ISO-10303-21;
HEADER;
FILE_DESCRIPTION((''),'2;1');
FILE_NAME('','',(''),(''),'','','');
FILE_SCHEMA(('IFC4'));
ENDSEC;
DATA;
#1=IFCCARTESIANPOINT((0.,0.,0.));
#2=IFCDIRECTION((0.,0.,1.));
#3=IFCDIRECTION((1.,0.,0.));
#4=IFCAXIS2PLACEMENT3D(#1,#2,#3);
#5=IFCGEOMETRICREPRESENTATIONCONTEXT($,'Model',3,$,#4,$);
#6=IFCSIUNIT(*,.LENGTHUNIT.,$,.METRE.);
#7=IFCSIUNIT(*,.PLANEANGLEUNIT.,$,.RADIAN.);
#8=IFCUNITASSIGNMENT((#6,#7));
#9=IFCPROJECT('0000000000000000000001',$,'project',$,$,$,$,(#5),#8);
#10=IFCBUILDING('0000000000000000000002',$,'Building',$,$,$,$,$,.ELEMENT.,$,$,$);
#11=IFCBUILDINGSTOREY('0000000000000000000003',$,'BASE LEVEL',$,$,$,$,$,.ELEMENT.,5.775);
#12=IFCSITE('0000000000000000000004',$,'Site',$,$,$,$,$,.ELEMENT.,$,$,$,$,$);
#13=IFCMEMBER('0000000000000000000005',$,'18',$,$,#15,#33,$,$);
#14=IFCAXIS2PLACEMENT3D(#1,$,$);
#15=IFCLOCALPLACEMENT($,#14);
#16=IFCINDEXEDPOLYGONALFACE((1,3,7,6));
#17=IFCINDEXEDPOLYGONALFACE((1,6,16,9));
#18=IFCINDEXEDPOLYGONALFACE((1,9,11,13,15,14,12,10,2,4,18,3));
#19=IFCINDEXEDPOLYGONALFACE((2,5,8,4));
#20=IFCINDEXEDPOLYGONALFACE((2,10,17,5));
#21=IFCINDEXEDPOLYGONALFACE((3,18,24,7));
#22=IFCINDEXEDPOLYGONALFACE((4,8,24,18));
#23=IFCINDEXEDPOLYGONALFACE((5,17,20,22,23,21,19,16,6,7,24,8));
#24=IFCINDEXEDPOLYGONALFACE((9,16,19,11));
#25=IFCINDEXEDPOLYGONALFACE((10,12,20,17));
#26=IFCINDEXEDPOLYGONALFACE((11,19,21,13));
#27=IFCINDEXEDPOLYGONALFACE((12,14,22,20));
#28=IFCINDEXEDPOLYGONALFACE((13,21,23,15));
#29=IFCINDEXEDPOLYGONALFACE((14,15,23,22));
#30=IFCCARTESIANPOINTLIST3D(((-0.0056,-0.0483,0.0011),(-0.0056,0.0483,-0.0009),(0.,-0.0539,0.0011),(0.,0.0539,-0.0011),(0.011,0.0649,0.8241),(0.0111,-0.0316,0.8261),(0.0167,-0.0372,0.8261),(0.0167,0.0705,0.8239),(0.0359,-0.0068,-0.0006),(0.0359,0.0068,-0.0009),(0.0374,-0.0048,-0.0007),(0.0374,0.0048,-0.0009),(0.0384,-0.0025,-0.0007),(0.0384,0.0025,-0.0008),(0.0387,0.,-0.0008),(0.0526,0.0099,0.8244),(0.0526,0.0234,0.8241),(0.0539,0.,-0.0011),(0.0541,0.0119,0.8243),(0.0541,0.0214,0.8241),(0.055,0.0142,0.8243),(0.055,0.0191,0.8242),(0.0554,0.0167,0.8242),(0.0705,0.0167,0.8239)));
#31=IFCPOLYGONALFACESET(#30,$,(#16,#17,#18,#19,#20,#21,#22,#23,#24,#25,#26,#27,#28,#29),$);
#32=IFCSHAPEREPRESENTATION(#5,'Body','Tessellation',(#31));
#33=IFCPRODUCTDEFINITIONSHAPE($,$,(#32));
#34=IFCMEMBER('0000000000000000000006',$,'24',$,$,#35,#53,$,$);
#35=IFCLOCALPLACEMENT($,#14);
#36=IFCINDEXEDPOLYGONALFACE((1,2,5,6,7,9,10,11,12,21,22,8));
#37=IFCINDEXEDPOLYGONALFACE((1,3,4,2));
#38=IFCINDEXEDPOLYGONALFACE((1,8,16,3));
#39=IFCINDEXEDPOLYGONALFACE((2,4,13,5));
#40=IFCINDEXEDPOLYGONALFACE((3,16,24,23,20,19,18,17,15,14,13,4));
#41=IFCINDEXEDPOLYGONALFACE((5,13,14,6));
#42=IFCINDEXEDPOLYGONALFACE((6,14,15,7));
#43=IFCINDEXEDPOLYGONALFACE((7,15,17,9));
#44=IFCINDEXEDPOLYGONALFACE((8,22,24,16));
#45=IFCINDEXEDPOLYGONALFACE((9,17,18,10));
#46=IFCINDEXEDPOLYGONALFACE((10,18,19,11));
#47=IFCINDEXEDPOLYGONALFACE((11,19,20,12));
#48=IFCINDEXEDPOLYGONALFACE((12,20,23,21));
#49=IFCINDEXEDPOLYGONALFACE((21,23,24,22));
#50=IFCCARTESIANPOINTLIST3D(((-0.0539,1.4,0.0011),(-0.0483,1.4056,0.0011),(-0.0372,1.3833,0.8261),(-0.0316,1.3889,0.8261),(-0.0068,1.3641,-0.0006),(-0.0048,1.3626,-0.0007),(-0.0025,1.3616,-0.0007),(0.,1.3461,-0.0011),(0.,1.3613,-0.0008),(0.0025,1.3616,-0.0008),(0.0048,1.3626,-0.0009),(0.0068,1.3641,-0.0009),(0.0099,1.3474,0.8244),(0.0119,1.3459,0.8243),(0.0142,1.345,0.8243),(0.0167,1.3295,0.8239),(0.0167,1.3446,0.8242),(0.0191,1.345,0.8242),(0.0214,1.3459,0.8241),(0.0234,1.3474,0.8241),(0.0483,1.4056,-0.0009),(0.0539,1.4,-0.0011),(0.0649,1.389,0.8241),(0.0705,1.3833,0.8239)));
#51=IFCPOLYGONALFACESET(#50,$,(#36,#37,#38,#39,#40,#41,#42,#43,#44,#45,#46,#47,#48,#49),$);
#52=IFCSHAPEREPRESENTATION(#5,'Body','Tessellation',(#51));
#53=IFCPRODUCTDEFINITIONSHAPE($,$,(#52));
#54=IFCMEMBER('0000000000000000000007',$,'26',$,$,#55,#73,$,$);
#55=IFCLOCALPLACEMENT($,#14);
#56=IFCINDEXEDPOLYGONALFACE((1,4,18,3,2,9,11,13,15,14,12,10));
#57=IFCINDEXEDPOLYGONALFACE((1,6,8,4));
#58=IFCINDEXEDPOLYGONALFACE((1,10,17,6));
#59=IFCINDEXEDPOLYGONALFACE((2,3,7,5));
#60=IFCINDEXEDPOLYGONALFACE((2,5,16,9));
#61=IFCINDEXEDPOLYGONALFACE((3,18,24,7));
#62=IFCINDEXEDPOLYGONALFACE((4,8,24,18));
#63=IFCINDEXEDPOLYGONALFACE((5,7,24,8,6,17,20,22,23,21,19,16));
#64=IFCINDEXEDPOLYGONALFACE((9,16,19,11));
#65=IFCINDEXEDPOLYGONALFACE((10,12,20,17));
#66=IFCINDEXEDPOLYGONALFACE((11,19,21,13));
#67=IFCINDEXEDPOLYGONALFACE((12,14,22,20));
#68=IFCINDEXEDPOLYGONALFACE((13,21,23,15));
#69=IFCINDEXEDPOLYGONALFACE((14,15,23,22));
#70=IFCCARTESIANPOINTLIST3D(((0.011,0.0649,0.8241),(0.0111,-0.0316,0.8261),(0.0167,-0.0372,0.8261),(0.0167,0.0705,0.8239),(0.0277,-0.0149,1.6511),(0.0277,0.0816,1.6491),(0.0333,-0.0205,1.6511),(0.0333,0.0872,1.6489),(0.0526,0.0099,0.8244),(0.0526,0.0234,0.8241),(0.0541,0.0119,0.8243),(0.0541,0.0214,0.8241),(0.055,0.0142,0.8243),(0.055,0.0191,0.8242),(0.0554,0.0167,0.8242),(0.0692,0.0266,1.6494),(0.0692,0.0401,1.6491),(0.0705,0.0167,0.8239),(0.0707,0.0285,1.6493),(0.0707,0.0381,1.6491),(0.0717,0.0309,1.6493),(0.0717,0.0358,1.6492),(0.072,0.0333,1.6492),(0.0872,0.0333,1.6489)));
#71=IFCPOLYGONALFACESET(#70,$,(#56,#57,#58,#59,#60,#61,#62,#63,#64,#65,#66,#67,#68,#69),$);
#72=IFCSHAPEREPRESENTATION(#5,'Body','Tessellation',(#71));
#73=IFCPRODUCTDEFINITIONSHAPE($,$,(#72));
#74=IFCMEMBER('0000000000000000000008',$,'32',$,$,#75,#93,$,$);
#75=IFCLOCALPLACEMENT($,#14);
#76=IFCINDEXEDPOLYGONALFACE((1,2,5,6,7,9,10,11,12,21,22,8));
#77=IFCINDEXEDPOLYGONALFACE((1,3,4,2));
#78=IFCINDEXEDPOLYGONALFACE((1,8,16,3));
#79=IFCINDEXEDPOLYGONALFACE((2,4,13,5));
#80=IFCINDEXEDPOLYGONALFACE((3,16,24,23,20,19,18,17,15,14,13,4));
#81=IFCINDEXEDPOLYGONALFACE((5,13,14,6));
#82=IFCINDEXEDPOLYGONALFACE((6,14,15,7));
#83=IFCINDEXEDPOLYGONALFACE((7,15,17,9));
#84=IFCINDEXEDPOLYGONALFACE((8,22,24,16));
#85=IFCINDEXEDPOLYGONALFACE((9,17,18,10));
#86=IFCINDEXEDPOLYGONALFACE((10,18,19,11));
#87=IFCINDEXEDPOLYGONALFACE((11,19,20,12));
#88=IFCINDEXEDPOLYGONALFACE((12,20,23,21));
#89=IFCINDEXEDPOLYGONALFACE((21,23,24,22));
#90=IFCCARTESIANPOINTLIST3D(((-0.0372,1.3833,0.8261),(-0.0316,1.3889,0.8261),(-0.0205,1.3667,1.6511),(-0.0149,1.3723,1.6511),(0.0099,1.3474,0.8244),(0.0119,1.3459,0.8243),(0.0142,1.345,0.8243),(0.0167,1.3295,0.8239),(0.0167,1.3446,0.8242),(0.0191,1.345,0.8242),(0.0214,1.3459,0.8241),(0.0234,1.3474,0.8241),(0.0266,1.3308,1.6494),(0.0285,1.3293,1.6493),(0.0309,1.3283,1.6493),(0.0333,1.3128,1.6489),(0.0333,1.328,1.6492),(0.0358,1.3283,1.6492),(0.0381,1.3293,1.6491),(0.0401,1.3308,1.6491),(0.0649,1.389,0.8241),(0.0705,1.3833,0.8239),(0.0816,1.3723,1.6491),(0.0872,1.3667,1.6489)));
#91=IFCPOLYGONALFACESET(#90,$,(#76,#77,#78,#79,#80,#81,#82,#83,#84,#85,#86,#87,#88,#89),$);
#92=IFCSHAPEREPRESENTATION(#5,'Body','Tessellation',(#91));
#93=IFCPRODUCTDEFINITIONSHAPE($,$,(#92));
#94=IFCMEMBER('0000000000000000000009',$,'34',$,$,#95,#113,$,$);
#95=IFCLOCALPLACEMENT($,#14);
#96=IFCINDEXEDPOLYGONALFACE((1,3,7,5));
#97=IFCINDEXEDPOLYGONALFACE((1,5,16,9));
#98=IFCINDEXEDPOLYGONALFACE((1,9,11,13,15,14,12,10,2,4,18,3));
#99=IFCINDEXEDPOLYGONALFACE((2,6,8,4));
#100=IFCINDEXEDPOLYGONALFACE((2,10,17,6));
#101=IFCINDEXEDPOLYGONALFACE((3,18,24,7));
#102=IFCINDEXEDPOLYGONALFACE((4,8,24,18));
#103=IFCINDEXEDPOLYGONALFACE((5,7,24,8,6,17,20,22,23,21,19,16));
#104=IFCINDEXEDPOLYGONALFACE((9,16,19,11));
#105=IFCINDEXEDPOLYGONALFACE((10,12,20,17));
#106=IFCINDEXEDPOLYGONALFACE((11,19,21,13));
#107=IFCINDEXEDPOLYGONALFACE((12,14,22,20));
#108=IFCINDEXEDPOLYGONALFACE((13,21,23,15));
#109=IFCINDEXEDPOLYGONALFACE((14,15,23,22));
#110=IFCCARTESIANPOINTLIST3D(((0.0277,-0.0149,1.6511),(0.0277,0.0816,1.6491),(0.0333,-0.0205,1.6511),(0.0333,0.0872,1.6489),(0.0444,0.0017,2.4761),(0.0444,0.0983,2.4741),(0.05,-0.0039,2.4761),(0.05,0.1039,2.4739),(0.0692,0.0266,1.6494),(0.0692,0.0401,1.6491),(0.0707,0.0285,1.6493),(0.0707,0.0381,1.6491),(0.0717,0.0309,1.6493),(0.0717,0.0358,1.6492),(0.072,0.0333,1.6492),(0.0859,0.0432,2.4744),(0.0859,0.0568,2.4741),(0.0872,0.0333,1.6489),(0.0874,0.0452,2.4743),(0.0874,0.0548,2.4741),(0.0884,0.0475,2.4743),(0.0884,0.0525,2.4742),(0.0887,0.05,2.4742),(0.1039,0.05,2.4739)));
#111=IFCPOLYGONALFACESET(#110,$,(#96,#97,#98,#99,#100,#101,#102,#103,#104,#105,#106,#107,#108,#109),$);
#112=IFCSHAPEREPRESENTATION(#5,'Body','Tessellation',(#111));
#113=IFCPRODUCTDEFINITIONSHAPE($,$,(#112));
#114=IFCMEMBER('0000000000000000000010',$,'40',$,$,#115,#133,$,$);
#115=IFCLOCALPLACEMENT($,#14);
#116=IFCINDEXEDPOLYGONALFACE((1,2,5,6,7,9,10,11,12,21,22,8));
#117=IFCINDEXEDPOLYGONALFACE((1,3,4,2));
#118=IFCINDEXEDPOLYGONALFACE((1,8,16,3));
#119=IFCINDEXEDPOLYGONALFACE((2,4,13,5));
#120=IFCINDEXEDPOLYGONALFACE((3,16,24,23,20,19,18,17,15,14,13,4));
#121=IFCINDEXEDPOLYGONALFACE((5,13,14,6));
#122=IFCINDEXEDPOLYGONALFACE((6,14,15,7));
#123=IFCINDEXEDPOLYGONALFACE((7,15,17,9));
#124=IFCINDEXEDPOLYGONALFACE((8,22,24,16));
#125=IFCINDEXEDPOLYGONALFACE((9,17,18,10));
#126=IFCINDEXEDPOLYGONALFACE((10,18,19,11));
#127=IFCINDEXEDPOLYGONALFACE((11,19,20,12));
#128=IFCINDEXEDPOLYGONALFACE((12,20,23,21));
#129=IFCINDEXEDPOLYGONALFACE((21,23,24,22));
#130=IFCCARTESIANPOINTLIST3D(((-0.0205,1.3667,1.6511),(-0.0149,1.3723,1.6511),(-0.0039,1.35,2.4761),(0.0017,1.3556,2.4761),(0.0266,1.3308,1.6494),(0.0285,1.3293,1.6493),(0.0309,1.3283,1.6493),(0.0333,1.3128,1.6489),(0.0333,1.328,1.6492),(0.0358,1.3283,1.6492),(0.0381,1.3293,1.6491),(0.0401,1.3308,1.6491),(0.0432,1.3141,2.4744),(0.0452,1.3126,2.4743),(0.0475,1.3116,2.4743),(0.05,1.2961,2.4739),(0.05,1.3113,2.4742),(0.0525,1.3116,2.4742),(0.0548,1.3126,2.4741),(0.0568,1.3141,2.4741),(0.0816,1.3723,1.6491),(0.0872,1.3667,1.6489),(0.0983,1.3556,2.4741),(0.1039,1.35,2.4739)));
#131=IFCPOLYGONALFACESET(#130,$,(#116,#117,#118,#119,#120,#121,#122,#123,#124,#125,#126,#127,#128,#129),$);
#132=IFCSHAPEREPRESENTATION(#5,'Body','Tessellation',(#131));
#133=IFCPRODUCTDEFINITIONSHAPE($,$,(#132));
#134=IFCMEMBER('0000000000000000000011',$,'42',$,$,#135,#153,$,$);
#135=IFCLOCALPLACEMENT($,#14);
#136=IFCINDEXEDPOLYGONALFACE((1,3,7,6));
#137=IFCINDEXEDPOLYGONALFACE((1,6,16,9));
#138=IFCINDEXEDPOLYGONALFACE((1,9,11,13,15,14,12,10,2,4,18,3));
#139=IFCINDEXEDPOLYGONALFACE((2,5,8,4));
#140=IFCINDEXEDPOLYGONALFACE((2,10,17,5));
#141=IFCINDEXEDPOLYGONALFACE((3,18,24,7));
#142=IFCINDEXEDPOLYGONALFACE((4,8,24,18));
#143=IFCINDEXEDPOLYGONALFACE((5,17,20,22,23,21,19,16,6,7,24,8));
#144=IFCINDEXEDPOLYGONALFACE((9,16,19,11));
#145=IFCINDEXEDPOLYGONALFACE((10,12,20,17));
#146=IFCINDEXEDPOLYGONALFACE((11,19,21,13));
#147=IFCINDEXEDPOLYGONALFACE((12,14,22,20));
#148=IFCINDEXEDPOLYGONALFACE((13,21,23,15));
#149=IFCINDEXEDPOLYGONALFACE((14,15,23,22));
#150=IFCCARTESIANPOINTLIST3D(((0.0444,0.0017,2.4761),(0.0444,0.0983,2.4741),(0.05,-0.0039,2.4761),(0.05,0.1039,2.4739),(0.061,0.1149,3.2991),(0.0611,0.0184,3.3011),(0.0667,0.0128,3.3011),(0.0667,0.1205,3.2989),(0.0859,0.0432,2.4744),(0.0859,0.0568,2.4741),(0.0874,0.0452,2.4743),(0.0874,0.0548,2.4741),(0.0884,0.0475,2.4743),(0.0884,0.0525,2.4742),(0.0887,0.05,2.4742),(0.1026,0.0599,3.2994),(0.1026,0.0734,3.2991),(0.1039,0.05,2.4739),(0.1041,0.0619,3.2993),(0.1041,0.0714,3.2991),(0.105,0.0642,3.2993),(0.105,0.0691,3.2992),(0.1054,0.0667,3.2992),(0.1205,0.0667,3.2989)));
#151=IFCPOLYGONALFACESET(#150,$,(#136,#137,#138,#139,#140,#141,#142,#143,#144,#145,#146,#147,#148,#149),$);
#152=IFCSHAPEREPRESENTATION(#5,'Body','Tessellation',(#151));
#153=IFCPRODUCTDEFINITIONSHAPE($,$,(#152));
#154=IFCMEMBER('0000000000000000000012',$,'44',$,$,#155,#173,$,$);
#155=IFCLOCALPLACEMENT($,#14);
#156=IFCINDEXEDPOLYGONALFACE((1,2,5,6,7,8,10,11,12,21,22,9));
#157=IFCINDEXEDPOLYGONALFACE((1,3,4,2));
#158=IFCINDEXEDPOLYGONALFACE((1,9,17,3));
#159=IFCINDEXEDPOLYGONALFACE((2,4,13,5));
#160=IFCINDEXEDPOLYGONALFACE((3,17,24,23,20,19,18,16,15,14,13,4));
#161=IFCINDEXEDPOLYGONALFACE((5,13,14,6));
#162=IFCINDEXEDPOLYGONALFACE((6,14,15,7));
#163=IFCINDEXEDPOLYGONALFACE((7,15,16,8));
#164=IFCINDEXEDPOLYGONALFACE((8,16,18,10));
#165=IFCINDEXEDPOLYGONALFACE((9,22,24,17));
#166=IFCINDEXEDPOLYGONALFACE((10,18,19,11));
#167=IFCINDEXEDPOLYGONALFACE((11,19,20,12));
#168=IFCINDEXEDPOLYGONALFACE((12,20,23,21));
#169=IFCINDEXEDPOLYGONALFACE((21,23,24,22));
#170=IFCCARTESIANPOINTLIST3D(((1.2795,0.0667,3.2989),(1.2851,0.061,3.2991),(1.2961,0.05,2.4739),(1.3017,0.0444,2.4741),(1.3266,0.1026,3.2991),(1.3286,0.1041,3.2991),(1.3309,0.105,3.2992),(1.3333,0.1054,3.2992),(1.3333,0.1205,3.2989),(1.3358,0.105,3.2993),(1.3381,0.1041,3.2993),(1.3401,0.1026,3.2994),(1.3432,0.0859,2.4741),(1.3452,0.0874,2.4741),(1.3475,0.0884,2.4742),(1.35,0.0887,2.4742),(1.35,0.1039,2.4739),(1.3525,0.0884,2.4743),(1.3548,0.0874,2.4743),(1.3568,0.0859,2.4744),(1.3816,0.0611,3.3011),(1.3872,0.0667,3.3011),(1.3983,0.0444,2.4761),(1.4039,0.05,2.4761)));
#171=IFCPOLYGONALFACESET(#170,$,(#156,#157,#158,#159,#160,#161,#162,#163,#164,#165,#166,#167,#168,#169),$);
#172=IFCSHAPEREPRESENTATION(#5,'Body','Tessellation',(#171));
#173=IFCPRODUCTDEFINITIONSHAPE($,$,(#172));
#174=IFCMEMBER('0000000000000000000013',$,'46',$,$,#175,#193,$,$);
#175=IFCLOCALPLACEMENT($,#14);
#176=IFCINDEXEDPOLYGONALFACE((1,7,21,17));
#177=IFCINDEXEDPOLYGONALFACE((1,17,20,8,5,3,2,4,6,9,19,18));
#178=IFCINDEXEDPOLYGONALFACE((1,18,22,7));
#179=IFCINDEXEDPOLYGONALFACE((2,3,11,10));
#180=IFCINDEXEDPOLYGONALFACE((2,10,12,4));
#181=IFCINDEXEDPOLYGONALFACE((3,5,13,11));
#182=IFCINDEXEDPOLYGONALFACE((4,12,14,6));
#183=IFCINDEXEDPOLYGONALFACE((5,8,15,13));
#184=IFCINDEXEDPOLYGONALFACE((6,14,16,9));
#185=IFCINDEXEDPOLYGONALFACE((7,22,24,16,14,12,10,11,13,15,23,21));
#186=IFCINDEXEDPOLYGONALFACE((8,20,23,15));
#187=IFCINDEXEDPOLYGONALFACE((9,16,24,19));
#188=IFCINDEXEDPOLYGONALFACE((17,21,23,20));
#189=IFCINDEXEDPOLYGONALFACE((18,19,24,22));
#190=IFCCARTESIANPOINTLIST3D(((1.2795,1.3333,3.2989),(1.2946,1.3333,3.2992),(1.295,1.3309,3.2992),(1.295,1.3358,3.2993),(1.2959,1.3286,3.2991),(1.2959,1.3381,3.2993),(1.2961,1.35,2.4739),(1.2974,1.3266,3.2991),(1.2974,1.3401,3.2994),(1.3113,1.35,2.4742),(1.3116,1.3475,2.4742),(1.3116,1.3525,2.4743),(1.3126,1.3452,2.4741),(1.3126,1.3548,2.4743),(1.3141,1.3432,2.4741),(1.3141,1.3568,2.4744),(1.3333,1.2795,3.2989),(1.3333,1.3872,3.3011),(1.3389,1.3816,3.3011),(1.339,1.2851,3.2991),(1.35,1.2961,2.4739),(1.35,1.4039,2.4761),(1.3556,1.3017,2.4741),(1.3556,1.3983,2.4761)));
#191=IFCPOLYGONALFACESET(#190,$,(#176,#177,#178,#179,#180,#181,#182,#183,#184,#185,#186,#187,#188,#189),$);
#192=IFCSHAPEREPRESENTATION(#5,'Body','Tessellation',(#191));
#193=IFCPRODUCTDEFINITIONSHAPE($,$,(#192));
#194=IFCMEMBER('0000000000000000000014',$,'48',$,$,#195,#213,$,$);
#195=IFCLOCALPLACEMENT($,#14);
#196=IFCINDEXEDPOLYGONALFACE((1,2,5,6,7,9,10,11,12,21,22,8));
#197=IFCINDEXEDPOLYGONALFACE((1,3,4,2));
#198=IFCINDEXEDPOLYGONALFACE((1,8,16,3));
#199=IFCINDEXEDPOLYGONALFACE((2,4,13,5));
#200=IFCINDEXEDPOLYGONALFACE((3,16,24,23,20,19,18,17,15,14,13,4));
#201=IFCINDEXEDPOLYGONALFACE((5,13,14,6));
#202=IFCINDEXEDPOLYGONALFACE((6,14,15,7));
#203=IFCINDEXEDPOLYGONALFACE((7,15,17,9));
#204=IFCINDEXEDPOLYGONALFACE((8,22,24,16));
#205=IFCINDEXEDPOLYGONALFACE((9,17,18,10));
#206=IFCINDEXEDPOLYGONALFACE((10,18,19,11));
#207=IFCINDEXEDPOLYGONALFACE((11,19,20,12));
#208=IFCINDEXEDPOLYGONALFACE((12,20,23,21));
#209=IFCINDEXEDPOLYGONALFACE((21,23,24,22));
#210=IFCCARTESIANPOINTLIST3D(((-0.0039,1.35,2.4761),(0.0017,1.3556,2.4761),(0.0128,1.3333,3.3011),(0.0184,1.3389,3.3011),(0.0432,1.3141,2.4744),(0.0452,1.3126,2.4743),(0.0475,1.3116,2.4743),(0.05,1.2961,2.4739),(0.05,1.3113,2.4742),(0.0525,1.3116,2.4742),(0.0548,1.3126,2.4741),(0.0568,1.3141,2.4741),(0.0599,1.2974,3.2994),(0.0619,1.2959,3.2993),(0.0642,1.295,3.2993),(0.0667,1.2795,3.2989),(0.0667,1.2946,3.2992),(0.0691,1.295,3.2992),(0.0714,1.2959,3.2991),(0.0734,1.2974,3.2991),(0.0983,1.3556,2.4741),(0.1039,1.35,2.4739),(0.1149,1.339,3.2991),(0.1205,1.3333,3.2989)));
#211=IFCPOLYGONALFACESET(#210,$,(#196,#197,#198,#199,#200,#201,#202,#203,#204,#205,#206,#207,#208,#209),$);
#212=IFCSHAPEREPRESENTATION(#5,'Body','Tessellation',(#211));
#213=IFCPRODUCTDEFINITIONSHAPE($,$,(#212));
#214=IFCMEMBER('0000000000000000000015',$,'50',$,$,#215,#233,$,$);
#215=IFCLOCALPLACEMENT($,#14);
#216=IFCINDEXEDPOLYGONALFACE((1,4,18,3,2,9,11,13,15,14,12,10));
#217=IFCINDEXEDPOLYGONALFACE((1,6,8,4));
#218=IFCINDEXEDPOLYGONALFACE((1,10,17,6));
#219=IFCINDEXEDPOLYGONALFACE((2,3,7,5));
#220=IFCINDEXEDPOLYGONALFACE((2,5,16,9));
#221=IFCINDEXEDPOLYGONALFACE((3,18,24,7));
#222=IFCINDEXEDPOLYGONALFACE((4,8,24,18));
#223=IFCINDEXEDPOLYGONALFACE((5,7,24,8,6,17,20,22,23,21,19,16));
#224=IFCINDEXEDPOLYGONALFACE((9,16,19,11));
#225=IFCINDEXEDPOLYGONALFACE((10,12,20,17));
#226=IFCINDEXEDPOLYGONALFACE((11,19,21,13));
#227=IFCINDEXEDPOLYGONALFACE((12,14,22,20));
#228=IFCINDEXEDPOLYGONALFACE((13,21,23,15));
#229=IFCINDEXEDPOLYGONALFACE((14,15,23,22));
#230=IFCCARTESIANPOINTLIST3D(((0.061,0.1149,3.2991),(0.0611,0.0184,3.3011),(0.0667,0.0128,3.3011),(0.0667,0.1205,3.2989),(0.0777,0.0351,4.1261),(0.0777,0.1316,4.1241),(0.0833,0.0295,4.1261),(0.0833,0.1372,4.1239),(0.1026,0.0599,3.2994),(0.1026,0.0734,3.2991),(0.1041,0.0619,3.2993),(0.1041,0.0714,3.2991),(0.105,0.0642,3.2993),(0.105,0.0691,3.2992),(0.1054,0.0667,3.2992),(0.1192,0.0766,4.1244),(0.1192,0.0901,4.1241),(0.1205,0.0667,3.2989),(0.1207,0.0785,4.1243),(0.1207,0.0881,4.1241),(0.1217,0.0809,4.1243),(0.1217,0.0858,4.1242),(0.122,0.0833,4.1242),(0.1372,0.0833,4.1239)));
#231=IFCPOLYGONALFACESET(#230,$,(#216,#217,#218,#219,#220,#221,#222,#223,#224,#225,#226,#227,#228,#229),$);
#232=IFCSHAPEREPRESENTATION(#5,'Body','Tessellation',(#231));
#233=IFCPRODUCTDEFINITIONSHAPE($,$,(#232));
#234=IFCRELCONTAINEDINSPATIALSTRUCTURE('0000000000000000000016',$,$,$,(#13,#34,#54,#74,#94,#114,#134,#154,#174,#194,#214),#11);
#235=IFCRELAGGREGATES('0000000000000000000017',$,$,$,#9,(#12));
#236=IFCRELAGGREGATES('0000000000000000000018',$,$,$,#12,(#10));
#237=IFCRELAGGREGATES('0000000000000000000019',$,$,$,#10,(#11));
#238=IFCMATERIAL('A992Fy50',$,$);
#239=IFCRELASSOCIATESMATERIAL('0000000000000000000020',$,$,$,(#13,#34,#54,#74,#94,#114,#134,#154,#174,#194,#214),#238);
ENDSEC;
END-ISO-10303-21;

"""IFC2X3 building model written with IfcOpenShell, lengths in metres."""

from ifc_helpers import new_model, si_unit, frame, origin_with_axes, origin_2d_with_axis, place, context, project, spatial, l_section, extrude, material, element, save


model = new_model("IFC2X3")

# Units and contexts
model_context = context("Model", 3, world=origin_with_axes())
ifc_project = project(units=[si_unit("LENGTHUNIT", "METRE"), si_unit("PLANEANGLEUNIT", "RADIAN")], contexts=[model_context])

# Site, building, storey
site = spatial("IfcSite", under=ifc_project, Name="Site", CompositionType="ELEMENT")
building = spatial("IfcBuilding", under=site, Name="Building", CompositionType="ELEMENT")
storey = spatial("IfcBuildingStorey", under=building, Name="BASE LEVEL", CompositionType="ELEMENT", Elevation=5.775)

# Members
ifc_material = material(Name="A992Fy50")
for number, where, z_axis, x_axis, name in (
    (1, (0.0, 0.0, 0.0), (0.020194, 0.020194, 0.999592), (-0.707107, 0.707107, 0.0), "18"),
    (2, (0.0, 1.4, 0.0), (0.020194, -0.020194, 0.999592), (0.707107, 0.707107, 0.0), "24"),
    (3, (0.0167, 0.0167, 0.825), (0.020194, 0.020194, 0.999592), (-0.707107, 0.707107, 0.0), "26"),
    (4, (0.0167, 1.3833, 0.825), (0.020194, -0.020194, 0.999592), (0.707107, 0.707107, 0.0), "32"),
    (5, (0.0333, 0.0333, 1.65), (0.020194, 0.020194, 0.999592), (-0.707107, 0.707107, 0.0), "34"),
    (6, (0.0333, 1.3667, 1.65), (0.020194, -0.020194, 0.999592), (0.707107, 0.707107, 0.0), "40"),
    (7, (0.05, 0.05, 2.475), (0.020194, 0.020194, 0.999592), (-0.707107, 0.707107, 0.0), "42"),
    (8, (1.35, 0.05, 2.475), (-0.020194, 0.020194, 0.999592), (-0.707107, -0.707107, 0.0), "44"),
    (9, (1.35, 1.35, 2.475), (-0.020194, -0.020194, 0.999592), (0.707107, -0.707107, 0.0), "46"),
    (10, (0.05, 1.35, 2.475), (0.020194, -0.020194, 0.999592), (0.707107, 0.707107, 0.0), "48"),
    (11, (0.0667, 0.0667, 3.3), (0.020194, 0.020194, 0.999592), (-0.707107, 0.707107, 0.0), "50"),
):
    element("IfcMember", number, at=place(None, frame(where, z_axis=z_axis, x_axis=x_axis)), inside=storey, material=ifc_material, Name=name, context=model_context, shape_type="SweptSolid", body=[
        extrude(l_section(Depth=0.0762, Width=0.0762, Thickness=0.0079, FilletRadius=0.0096, at=origin_2d_with_axis()), origin_with_axes(), (0.0, 0.0, 1.0), 0.8253),
    ])

save(model, "model.ifc")
